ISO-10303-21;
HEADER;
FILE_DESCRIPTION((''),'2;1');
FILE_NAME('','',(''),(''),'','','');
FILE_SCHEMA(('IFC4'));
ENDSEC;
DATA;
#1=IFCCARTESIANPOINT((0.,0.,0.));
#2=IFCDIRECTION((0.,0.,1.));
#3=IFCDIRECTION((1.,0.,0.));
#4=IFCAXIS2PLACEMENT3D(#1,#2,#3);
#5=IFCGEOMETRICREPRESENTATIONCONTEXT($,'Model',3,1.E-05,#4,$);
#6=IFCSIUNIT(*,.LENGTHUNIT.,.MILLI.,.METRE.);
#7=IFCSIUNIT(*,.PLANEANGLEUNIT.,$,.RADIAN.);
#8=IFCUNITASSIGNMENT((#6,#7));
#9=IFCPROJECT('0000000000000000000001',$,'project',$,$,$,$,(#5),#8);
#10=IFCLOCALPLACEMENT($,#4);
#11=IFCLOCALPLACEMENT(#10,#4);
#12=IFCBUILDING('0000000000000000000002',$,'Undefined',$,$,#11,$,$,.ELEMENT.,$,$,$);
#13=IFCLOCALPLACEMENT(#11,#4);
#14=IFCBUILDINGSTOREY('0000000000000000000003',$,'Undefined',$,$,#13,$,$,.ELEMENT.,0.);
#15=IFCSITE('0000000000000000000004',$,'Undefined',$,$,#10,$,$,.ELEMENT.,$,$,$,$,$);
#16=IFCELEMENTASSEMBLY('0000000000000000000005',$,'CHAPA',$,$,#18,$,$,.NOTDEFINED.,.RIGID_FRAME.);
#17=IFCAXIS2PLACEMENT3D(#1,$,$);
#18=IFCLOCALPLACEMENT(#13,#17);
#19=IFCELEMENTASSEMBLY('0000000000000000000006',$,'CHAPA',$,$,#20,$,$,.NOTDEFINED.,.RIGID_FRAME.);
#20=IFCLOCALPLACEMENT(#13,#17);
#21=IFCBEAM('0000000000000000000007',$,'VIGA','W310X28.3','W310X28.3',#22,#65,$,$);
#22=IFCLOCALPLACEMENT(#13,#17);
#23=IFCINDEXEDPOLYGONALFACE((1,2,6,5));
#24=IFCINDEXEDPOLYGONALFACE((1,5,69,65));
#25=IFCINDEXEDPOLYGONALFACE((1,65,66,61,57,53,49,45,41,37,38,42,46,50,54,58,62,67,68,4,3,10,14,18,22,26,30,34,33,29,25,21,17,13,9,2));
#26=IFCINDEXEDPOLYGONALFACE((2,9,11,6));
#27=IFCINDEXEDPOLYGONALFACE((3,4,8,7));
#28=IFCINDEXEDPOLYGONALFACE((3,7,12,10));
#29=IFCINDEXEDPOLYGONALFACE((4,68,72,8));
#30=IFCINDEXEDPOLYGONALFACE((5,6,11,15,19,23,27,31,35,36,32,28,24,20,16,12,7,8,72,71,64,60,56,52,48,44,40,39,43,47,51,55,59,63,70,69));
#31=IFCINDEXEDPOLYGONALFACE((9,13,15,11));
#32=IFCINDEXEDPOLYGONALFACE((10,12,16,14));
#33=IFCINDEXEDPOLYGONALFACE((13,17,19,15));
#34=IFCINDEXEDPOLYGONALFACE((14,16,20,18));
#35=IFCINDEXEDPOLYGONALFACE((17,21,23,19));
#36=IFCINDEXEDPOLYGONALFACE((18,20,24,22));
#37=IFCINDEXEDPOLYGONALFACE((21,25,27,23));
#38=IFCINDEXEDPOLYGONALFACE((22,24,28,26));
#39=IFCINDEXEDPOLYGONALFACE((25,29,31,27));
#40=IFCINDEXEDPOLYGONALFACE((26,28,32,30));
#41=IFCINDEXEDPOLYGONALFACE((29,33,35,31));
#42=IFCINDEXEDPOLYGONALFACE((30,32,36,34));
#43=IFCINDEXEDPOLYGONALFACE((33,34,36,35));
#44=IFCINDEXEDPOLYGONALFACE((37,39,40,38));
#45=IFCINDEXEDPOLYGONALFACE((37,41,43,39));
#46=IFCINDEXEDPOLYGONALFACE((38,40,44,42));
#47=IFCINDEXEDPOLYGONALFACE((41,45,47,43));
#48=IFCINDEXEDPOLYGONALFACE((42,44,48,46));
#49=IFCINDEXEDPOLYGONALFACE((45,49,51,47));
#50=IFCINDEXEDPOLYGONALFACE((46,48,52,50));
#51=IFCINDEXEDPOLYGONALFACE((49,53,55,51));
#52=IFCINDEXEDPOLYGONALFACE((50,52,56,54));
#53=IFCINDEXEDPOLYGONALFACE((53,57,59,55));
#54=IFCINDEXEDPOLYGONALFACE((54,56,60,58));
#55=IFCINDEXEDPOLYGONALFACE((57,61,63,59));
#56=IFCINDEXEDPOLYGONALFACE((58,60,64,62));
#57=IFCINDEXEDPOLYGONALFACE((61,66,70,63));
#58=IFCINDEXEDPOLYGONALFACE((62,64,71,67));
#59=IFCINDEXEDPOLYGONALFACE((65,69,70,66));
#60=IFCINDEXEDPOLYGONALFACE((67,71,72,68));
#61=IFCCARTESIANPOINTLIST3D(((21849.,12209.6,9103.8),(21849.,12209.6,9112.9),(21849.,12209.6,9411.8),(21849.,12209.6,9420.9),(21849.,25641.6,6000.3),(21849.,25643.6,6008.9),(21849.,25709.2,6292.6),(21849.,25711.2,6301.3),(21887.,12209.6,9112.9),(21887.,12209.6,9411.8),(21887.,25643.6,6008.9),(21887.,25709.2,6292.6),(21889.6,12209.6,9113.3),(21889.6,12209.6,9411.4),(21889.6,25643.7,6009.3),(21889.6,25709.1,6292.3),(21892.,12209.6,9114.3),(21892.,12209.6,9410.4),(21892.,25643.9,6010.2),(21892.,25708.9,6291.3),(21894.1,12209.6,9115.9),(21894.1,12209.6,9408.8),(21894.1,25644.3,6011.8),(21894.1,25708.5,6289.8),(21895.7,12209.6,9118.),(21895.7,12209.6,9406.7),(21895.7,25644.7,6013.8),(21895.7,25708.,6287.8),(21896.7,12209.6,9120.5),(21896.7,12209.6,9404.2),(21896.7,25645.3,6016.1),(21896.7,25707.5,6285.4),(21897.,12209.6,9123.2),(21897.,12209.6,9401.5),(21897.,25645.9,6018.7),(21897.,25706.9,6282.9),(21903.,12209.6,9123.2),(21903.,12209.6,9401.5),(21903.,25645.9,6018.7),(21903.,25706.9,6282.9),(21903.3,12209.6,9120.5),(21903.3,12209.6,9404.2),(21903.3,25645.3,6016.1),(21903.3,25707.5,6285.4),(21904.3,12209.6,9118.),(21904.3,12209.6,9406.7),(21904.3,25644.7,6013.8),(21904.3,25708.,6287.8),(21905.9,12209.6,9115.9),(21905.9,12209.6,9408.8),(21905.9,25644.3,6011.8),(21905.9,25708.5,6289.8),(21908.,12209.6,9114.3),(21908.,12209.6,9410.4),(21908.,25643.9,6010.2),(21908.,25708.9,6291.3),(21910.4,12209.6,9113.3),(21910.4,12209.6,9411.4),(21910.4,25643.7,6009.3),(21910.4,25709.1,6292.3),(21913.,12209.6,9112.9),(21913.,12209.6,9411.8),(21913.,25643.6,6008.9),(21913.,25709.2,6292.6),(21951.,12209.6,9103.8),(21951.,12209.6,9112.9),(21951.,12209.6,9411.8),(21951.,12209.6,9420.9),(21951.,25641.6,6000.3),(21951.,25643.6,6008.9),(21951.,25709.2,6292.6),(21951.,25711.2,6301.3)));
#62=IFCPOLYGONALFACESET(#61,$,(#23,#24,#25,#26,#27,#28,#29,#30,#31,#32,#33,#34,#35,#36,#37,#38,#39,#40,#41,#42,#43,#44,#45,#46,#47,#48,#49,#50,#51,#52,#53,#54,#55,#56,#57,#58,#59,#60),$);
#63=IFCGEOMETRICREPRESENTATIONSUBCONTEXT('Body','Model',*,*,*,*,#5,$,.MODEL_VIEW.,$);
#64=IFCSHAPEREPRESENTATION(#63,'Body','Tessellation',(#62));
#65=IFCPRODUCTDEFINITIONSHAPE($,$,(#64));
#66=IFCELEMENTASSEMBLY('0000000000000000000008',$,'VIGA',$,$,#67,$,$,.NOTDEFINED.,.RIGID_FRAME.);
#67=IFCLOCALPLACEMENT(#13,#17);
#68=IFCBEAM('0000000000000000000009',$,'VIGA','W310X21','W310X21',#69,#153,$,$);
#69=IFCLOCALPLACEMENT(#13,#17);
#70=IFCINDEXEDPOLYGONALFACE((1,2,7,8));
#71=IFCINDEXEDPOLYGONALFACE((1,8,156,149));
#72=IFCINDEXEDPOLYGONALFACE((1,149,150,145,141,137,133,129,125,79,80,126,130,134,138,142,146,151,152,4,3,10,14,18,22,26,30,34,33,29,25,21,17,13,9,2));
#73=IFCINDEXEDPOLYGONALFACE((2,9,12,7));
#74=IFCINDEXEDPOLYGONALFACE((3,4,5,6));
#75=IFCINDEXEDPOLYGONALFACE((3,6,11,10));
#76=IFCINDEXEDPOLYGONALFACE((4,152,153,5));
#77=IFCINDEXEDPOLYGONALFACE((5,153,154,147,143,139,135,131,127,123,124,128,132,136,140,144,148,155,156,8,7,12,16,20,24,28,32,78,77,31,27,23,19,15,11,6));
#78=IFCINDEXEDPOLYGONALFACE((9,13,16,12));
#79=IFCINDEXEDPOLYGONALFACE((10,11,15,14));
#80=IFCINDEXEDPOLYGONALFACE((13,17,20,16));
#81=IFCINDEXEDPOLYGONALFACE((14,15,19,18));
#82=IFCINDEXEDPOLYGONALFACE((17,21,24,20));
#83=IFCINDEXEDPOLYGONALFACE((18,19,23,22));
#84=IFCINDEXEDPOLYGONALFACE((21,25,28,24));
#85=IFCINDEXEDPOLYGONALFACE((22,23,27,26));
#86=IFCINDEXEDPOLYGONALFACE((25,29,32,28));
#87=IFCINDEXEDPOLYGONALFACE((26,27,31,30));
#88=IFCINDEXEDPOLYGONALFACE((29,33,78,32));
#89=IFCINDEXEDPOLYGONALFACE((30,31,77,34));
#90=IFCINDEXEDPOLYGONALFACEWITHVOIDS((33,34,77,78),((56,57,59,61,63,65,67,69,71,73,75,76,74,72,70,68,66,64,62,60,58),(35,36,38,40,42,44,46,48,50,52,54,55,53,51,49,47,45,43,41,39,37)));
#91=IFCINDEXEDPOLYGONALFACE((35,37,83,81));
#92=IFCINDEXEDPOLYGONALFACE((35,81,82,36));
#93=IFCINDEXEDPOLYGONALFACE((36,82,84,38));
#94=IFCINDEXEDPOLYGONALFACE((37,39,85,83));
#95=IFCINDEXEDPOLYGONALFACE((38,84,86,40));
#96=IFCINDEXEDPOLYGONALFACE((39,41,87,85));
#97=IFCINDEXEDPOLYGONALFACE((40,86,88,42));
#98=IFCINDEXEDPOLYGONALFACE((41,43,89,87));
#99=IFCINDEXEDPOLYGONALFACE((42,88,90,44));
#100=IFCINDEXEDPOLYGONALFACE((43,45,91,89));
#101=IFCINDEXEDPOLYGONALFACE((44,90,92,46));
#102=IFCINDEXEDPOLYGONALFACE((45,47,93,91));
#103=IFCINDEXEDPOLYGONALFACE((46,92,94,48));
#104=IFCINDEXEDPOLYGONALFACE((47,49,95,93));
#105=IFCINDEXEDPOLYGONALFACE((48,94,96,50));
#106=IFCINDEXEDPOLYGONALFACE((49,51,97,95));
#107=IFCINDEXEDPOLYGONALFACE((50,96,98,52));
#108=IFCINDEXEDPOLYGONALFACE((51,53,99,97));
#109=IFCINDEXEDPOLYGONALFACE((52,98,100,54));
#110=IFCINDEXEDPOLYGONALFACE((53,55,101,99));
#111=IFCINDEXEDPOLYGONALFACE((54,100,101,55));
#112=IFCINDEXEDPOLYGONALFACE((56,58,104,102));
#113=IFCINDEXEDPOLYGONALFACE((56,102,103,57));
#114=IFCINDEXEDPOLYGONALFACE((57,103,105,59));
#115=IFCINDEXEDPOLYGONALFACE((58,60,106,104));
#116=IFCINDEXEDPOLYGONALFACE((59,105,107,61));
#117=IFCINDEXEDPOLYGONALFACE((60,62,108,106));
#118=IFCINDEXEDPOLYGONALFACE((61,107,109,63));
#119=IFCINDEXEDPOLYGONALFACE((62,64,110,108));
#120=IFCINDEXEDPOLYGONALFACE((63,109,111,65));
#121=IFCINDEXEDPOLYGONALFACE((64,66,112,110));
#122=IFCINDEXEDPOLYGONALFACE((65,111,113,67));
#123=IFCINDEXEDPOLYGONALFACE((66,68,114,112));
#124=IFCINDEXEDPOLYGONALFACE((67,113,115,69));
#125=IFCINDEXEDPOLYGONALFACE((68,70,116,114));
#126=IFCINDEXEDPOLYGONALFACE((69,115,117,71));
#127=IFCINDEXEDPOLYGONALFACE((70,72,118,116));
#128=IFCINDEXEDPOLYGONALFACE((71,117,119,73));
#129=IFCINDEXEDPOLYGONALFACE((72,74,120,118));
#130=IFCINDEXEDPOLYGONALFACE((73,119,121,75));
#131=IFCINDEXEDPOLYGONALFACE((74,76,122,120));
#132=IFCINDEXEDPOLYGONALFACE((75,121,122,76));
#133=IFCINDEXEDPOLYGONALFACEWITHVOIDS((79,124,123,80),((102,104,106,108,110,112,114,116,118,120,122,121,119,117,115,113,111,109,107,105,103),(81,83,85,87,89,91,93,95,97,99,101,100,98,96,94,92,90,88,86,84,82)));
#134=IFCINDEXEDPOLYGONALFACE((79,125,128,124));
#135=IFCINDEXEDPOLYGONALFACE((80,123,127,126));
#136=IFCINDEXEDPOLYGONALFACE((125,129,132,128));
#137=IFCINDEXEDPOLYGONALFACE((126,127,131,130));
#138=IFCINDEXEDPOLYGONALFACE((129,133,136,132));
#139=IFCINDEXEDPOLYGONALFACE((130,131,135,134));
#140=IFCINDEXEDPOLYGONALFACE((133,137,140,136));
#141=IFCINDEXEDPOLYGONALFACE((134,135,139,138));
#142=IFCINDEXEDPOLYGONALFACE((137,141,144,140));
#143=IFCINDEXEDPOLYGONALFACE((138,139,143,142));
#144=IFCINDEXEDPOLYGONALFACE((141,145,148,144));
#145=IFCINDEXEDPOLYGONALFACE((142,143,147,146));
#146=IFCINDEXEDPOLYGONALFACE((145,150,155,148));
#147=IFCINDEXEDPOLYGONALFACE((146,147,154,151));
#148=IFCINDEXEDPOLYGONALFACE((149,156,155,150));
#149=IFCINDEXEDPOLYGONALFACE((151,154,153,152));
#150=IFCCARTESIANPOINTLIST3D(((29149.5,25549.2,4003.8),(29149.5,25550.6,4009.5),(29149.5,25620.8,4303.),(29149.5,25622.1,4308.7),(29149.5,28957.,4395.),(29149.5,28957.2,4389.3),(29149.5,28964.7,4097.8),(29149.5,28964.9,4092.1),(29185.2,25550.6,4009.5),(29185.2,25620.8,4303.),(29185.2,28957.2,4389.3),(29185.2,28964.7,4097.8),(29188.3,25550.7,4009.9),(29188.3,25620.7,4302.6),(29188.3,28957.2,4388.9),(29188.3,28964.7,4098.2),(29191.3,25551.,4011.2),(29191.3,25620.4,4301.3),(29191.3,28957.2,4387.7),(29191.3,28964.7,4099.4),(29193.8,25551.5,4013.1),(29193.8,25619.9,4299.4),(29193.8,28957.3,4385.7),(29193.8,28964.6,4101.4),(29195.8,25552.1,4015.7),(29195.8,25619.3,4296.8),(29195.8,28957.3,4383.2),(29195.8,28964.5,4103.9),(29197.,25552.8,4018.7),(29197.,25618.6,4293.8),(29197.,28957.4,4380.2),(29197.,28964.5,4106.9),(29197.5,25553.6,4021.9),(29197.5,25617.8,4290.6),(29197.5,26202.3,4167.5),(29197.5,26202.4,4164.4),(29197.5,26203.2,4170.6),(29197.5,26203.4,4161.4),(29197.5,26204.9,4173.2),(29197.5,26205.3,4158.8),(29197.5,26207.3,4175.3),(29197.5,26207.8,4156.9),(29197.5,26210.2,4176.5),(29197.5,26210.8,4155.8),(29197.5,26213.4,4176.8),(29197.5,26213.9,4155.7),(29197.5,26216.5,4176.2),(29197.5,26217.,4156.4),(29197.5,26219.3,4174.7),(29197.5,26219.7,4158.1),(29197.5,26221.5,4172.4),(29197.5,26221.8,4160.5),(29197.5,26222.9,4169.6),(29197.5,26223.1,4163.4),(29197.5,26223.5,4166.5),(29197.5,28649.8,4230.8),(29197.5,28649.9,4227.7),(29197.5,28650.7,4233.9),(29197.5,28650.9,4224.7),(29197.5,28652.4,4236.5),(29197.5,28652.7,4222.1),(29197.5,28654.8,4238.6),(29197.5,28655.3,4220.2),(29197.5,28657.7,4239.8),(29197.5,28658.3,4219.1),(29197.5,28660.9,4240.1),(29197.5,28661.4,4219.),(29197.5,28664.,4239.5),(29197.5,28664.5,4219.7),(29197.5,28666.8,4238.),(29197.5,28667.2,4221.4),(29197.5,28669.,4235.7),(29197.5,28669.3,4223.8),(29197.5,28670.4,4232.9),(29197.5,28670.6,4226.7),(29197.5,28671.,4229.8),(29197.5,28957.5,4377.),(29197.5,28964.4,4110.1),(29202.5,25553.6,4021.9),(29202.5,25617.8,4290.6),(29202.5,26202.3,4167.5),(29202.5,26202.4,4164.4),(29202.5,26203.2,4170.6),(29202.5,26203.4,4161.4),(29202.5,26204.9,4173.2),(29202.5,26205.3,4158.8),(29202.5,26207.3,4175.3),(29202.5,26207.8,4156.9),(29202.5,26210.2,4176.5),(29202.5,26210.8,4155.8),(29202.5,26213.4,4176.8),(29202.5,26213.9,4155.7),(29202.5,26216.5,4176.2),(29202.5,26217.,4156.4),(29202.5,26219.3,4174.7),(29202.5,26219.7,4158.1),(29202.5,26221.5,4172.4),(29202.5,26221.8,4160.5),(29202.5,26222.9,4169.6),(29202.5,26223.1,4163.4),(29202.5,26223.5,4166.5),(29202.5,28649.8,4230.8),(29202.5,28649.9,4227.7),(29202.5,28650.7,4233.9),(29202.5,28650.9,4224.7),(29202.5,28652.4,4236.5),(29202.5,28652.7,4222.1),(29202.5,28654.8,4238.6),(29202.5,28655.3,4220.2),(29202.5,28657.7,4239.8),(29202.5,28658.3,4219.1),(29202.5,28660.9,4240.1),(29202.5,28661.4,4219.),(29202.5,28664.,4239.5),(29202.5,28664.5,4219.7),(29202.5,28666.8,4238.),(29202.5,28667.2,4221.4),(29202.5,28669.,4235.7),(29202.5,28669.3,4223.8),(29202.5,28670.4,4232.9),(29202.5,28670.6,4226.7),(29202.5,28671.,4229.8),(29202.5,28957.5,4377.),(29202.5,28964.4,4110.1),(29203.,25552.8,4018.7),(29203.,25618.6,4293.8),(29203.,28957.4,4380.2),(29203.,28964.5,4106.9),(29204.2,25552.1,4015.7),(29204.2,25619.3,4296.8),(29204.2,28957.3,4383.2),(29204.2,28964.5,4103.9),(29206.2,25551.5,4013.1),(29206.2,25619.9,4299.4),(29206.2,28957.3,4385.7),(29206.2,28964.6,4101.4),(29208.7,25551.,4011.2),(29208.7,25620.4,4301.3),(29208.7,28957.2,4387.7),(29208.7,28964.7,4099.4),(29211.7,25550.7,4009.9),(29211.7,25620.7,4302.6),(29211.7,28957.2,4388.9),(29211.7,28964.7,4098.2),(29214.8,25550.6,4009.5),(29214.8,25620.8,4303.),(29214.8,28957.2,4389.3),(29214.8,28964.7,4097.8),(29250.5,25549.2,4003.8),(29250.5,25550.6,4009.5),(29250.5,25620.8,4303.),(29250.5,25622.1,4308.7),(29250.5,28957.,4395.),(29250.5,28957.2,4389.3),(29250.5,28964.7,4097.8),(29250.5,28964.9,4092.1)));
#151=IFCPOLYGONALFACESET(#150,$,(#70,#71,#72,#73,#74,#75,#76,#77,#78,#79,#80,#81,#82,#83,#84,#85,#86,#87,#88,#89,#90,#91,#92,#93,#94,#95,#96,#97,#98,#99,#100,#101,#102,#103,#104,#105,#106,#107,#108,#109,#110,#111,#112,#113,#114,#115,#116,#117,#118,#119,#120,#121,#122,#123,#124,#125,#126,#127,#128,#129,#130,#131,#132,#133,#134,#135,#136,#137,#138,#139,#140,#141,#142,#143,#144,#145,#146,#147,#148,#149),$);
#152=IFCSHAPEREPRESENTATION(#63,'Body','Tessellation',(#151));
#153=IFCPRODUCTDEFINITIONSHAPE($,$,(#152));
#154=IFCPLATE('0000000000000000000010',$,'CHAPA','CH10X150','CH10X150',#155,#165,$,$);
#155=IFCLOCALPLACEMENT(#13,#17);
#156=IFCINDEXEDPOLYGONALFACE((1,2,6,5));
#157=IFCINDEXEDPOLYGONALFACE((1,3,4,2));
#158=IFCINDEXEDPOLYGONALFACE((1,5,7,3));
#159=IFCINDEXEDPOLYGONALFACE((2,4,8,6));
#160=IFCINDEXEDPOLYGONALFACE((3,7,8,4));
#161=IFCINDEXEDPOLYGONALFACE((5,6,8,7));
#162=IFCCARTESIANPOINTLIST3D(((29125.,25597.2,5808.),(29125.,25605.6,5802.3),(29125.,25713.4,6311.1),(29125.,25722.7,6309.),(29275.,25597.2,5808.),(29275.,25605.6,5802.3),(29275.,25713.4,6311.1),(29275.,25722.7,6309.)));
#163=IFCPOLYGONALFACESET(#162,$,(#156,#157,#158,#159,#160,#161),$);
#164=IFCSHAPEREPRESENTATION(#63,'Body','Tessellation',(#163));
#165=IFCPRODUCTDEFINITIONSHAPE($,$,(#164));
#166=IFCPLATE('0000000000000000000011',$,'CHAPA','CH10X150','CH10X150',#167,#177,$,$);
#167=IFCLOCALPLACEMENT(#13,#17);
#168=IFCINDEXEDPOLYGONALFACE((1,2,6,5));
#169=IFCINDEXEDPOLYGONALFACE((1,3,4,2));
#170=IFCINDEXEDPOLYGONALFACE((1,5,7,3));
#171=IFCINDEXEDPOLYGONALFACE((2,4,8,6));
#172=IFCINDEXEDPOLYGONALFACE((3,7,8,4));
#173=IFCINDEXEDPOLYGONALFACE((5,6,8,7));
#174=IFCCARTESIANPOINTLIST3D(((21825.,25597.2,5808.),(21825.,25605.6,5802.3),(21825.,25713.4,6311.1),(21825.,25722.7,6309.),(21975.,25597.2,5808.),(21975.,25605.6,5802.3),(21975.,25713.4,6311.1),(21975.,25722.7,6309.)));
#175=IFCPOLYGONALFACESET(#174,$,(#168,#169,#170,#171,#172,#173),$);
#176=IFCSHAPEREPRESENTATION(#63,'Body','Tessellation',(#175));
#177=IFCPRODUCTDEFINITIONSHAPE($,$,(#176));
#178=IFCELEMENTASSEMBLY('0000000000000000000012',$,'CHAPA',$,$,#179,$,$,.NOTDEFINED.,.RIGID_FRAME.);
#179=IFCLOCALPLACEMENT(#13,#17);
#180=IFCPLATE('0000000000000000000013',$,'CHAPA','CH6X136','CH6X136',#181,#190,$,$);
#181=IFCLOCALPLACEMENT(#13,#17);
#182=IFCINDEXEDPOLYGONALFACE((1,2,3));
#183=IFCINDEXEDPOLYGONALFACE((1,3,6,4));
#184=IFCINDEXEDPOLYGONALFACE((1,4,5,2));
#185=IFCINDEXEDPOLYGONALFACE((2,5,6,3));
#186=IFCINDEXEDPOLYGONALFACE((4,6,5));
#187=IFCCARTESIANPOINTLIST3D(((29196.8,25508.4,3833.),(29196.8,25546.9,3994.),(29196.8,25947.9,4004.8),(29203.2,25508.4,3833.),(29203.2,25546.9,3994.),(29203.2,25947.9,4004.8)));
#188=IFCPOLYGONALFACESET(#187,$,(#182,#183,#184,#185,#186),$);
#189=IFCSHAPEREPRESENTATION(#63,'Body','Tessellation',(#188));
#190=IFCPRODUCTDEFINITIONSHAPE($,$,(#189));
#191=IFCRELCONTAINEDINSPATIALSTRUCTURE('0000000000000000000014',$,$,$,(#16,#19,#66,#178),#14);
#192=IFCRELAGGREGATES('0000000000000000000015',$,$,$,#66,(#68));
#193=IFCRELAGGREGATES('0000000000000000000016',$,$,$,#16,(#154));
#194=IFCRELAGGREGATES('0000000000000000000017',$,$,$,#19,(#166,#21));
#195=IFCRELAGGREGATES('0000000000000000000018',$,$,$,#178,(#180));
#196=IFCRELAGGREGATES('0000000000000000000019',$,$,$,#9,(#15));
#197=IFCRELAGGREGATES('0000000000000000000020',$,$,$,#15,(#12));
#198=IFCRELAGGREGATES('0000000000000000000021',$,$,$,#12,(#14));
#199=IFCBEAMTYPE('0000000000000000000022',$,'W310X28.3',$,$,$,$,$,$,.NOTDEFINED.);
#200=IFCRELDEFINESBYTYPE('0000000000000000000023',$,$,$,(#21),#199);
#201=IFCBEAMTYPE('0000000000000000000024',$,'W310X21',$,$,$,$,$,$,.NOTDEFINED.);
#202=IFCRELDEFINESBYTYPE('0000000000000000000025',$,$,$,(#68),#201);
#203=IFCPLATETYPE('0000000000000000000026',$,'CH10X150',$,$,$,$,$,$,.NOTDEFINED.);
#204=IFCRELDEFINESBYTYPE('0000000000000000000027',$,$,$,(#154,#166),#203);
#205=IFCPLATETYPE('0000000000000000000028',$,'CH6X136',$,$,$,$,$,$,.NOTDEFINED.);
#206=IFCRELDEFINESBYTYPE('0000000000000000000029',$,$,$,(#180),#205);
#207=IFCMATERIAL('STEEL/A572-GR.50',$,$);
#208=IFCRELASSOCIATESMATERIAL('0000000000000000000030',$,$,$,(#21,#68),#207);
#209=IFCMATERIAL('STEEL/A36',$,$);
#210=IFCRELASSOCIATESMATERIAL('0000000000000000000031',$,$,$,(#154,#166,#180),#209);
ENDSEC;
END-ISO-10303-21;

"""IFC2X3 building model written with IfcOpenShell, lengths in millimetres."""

from ifc_helpers import new_model, si_unit, frame, origin_with_axes, origin_2d_with_axis, place, context, subcontext, project, spatial, polyline, circle, i_section, outline, extrude, boolean, clip, halfspace, material, type_object, element, aggregate, save


model = new_model("IFC2X3")

# Units and contexts
model_context = context("Model", 3, precision=1e-05, world=origin_with_axes())
body_context = subcontext(model_context, "Body", "Model", "MODEL_VIEW")
ifc_project = project(units=[si_unit("LENGTHUNIT", "METRE", prefix="MILLI"), si_unit("PLANEANGLEUNIT", "RADIAN")], contexts=[model_context])

# Site, building, storey
site_placement = place(None, origin_with_axes())
site = spatial("IfcSite", under=ifc_project, at=site_placement, Name="Undefined", CompositionType="ELEMENT")
building_placement = place(site_placement, origin_with_axes())
building = spatial("IfcBuilding", under=site, at=building_placement, Name="Undefined", CompositionType="ELEMENT")
storey_placement = place(building_placement, origin_with_axes())
storey = spatial("IfcBuildingStorey", under=building, at=storey_placement, Name="Undefined", CompositionType="ELEMENT", Elevation=0.0)

# Element assemblies, beams
assembly_1_placement = place(storey_placement, origin_with_axes())
assembly_1 = element("IfcElementAssembly", 1, at=assembly_1_placement, inside=storey, Name="CHAPA", AssemblyPlace="NOTDEFINED", PredefinedType="RIGID_FRAME")
ifc_material_1 = material(Name="STEEL/A572-GR.50")
beam_type_1 = type_object("IfcBeamType", Name="W310X28.3", PredefinedType="NOTDEFINED")
assembly_2_placement = place(storey_placement, origin_with_axes())
assembly_2 = element("IfcElementAssembly", 2, at=assembly_2_placement, inside=storey, Name="CHAPA", AssemblyPlace="NOTDEFINED", PredefinedType="RIGID_FRAME")
beam_1_placement = place(assembly_2_placement, frame((21900.0, 25676.4, 6150.8), z_axis=(0.0, -0.225124, -0.97433), x_axis=(0.0, -0.97433, 0.225124)))
beam_1 = element("IfcBeam", 3, at=beam_1_placement, type_object=beam_type_1, material=ifc_material_1, Name="VIGA", Description="W310X28.3", ObjectType="W310X28.3", context=body_context, shape_type="Clipping", body=[
    clip(extrude(i_section(OverallWidth=102.0, OverallDepth=309.0, WebThickness=6.0, FlangeThickness=8.9, FilletRadius=10.0, at=origin_2d_with_axis()), frame((13995.7, 0.0, 0.0), z_axis=(-1.0, 0.0, 0.0), x_axis=(0.0, -1.0, 0.0)), (0.0, 0.0, 1.0), 13995.7), halfspace(frame((13786.4, 0.0, 152.3), z_axis=(0.97433, 0.0, 0.225124), x_axis=(0.225124, 0.0, -0.97433)), False)),
])
assembly_3_placement = place(storey_placement, origin_with_axes())
assembly_3 = element("IfcElementAssembly", 4, at=assembly_3_placement, inside=storey, Name="VIGA", AssemblyPlace="NOTDEFINED", PredefinedType="RIGID_FRAME")
beam_type_2 = type_object("IfcBeamType", Name="W310X21", PredefinedType="NOTDEFINED")
beam_2_placement = place(assembly_3_placement, frame((29200.0, 25403.9, 4151.6), z_axis=(0.0, -0.025855, 0.999666), x_axis=(0.0, 0.999666, 0.025855)))
beam_2 = element("IfcBeam", 5, at=beam_2_placement, type_object=beam_type_2, material=ifc_material_1, Name="VIGA", Description="W310X21", ObjectType="W310X21", context=body_context, shape_type="CSG", body=[
    boolean("DIFFERENCE", boolean("DIFFERENCE", boolean("DIFFERENCE", extrude(i_section(OverallWidth=101.0, OverallDepth=303.0, WebThickness=5.1, FlangeThickness=5.7, FilletRadius=12.3, at=origin_2d_with_axis()), frame((3558.2, 0.0, 0.0), z_axis=(-1.0, 0.0, 0.0), x_axis=(0.0, -1.0, 0.0)), (0.0, 0.0, 1.0), 3558.2), extrude(circle(Radius=10.6, at=origin_2d_with_axis()), frame((809.1, 100.0, -6.3), z_axis=(0.0, -1.0, 0.0), x_axis=(1.0, 0.0, 0.0)), (0.0, 0.0, 1.0), 200.0)), extrude(circle(Radius=10.6, at=origin_2d_with_axis()), frame((3257.4, 100.0, -6.3), z_axis=(0.0, -1.0, 0.0), x_axis=(1.0, 0.0, 0.0)), (0.0, 0.0, 1.0), 200.0)), halfspace(frame((141.4, -50.5, -151.7), z_axis=(-0.966259, 0.0, 0.257573), x_axis=(0.0, 1.0, 0.0)), False)),
])
aggregate(assembly_3, [beam_2])

# Plates
ifc_material_2 = material(Name="STEEL/A36")
plate_type_1 = type_object("IfcPlateType", Name="CH10X150", PredefinedType="NOTDEFINED")
plate_1_placement = place(assembly_1_placement, frame((29275.0, 25718.1, 6310.1), z_axis=(0.0, 0.97433, -0.225124), x_axis=(0.0, -0.225124, -0.97433)))
plate_1 = element("IfcPlate", 6, at=plate_1_placement, type_object=plate_type_1, material=ifc_material_2, Name="CHAPA", Description="CH10X150", ObjectType="CH10X150", context=body_context, shape_type="Clipping", body=[
    clip(extrude(outline(polyline([(0.0, 0.0), (520.0, 0.0), (520.0, 150.0), (0.0, 150.0), (0.0, 0.0)])), frame((0.0, 0.0, -4.8), z_axis=(0.0, 0.0, 1.0), x_axis=(1.0, 0.0, 0.0)), (0.0, 0.0, 1.0), 9.5), halfspace(frame((516.4, -500.0, -4.7), z_axis=(0.934951, 0.0, -0.354778), x_axis=(0.354778, 0.0, 0.934951)), False)),
])
aggregate(assembly_1, [plate_1])
plate_2_placement = place(assembly_2_placement, frame((21975.0, 25718.1, 6310.1), z_axis=(0.0, 0.97433, -0.225124), x_axis=(0.0, -0.225124, -0.97433)))
plate_2 = element("IfcPlate", 7, at=plate_2_placement, type_object=plate_type_1, material=ifc_material_2, Name="CHAPA", Description="CH10X150", ObjectType="CH10X150", context=body_context, shape_type="Clipping", body=[
    clip(extrude(outline(polyline([(0.0, 0.0), (520.0, 0.0), (520.0, 150.0), (0.0, 150.0), (0.0, 0.0)])), frame((0.0, 0.0, -4.8), z_axis=(0.0, 0.0, 1.0), x_axis=(1.0, 0.0, 0.0)), (0.0, 0.0, 1.0), 9.5), halfspace(frame((516.4, -500.0, -4.7), z_axis=(0.934951, 0.0, -0.354778), x_axis=(0.354778, 0.0, 0.934951)), False)),
])
aggregate(assembly_2, [plate_2, beam_1])

# Element assembly, plate
assembly_4_placement = place(storey_placement, origin_with_axes())
assembly_4 = element("IfcElementAssembly", 8, at=assembly_4_placement, inside=storey, Name="CHAPA", AssemblyPlace="NOTDEFINED", PredefinedType="RIGID_FRAME")
plate_type_2 = type_object("IfcPlateType", Name="CH6X136", PredefinedType="NOTDEFINED")
plate_3_placement = place(assembly_4_placement, frame((29200.0, 25546.9, 3994.0), z_axis=(-1.0, 0.0, 0.0), x_axis=(0.0, 0.999636, 0.026972)))
plate_3 = element("IfcPlate", 9, at=plate_3_placement, type_object=plate_type_2, material=ifc_material_2, Name="CHAPA", Description="CH6X136", ObjectType="CH6X136", context=body_context, shape_type="SweptSolid", body=[
    extrude(outline(polyline([(0.0, 0.0), (401.1, 0.0), (-42.8, 159.9), (0.0, 0.0)])), frame((0.0, 0.0, -3.1), z_axis=(0.0, 0.0, 1.0), x_axis=(1.0, 0.0, 0.0)), (0.0, 0.0, 1.0), 6.3),
])
aggregate(assembly_4, [plate_3])

save(model, "model.ifc")
